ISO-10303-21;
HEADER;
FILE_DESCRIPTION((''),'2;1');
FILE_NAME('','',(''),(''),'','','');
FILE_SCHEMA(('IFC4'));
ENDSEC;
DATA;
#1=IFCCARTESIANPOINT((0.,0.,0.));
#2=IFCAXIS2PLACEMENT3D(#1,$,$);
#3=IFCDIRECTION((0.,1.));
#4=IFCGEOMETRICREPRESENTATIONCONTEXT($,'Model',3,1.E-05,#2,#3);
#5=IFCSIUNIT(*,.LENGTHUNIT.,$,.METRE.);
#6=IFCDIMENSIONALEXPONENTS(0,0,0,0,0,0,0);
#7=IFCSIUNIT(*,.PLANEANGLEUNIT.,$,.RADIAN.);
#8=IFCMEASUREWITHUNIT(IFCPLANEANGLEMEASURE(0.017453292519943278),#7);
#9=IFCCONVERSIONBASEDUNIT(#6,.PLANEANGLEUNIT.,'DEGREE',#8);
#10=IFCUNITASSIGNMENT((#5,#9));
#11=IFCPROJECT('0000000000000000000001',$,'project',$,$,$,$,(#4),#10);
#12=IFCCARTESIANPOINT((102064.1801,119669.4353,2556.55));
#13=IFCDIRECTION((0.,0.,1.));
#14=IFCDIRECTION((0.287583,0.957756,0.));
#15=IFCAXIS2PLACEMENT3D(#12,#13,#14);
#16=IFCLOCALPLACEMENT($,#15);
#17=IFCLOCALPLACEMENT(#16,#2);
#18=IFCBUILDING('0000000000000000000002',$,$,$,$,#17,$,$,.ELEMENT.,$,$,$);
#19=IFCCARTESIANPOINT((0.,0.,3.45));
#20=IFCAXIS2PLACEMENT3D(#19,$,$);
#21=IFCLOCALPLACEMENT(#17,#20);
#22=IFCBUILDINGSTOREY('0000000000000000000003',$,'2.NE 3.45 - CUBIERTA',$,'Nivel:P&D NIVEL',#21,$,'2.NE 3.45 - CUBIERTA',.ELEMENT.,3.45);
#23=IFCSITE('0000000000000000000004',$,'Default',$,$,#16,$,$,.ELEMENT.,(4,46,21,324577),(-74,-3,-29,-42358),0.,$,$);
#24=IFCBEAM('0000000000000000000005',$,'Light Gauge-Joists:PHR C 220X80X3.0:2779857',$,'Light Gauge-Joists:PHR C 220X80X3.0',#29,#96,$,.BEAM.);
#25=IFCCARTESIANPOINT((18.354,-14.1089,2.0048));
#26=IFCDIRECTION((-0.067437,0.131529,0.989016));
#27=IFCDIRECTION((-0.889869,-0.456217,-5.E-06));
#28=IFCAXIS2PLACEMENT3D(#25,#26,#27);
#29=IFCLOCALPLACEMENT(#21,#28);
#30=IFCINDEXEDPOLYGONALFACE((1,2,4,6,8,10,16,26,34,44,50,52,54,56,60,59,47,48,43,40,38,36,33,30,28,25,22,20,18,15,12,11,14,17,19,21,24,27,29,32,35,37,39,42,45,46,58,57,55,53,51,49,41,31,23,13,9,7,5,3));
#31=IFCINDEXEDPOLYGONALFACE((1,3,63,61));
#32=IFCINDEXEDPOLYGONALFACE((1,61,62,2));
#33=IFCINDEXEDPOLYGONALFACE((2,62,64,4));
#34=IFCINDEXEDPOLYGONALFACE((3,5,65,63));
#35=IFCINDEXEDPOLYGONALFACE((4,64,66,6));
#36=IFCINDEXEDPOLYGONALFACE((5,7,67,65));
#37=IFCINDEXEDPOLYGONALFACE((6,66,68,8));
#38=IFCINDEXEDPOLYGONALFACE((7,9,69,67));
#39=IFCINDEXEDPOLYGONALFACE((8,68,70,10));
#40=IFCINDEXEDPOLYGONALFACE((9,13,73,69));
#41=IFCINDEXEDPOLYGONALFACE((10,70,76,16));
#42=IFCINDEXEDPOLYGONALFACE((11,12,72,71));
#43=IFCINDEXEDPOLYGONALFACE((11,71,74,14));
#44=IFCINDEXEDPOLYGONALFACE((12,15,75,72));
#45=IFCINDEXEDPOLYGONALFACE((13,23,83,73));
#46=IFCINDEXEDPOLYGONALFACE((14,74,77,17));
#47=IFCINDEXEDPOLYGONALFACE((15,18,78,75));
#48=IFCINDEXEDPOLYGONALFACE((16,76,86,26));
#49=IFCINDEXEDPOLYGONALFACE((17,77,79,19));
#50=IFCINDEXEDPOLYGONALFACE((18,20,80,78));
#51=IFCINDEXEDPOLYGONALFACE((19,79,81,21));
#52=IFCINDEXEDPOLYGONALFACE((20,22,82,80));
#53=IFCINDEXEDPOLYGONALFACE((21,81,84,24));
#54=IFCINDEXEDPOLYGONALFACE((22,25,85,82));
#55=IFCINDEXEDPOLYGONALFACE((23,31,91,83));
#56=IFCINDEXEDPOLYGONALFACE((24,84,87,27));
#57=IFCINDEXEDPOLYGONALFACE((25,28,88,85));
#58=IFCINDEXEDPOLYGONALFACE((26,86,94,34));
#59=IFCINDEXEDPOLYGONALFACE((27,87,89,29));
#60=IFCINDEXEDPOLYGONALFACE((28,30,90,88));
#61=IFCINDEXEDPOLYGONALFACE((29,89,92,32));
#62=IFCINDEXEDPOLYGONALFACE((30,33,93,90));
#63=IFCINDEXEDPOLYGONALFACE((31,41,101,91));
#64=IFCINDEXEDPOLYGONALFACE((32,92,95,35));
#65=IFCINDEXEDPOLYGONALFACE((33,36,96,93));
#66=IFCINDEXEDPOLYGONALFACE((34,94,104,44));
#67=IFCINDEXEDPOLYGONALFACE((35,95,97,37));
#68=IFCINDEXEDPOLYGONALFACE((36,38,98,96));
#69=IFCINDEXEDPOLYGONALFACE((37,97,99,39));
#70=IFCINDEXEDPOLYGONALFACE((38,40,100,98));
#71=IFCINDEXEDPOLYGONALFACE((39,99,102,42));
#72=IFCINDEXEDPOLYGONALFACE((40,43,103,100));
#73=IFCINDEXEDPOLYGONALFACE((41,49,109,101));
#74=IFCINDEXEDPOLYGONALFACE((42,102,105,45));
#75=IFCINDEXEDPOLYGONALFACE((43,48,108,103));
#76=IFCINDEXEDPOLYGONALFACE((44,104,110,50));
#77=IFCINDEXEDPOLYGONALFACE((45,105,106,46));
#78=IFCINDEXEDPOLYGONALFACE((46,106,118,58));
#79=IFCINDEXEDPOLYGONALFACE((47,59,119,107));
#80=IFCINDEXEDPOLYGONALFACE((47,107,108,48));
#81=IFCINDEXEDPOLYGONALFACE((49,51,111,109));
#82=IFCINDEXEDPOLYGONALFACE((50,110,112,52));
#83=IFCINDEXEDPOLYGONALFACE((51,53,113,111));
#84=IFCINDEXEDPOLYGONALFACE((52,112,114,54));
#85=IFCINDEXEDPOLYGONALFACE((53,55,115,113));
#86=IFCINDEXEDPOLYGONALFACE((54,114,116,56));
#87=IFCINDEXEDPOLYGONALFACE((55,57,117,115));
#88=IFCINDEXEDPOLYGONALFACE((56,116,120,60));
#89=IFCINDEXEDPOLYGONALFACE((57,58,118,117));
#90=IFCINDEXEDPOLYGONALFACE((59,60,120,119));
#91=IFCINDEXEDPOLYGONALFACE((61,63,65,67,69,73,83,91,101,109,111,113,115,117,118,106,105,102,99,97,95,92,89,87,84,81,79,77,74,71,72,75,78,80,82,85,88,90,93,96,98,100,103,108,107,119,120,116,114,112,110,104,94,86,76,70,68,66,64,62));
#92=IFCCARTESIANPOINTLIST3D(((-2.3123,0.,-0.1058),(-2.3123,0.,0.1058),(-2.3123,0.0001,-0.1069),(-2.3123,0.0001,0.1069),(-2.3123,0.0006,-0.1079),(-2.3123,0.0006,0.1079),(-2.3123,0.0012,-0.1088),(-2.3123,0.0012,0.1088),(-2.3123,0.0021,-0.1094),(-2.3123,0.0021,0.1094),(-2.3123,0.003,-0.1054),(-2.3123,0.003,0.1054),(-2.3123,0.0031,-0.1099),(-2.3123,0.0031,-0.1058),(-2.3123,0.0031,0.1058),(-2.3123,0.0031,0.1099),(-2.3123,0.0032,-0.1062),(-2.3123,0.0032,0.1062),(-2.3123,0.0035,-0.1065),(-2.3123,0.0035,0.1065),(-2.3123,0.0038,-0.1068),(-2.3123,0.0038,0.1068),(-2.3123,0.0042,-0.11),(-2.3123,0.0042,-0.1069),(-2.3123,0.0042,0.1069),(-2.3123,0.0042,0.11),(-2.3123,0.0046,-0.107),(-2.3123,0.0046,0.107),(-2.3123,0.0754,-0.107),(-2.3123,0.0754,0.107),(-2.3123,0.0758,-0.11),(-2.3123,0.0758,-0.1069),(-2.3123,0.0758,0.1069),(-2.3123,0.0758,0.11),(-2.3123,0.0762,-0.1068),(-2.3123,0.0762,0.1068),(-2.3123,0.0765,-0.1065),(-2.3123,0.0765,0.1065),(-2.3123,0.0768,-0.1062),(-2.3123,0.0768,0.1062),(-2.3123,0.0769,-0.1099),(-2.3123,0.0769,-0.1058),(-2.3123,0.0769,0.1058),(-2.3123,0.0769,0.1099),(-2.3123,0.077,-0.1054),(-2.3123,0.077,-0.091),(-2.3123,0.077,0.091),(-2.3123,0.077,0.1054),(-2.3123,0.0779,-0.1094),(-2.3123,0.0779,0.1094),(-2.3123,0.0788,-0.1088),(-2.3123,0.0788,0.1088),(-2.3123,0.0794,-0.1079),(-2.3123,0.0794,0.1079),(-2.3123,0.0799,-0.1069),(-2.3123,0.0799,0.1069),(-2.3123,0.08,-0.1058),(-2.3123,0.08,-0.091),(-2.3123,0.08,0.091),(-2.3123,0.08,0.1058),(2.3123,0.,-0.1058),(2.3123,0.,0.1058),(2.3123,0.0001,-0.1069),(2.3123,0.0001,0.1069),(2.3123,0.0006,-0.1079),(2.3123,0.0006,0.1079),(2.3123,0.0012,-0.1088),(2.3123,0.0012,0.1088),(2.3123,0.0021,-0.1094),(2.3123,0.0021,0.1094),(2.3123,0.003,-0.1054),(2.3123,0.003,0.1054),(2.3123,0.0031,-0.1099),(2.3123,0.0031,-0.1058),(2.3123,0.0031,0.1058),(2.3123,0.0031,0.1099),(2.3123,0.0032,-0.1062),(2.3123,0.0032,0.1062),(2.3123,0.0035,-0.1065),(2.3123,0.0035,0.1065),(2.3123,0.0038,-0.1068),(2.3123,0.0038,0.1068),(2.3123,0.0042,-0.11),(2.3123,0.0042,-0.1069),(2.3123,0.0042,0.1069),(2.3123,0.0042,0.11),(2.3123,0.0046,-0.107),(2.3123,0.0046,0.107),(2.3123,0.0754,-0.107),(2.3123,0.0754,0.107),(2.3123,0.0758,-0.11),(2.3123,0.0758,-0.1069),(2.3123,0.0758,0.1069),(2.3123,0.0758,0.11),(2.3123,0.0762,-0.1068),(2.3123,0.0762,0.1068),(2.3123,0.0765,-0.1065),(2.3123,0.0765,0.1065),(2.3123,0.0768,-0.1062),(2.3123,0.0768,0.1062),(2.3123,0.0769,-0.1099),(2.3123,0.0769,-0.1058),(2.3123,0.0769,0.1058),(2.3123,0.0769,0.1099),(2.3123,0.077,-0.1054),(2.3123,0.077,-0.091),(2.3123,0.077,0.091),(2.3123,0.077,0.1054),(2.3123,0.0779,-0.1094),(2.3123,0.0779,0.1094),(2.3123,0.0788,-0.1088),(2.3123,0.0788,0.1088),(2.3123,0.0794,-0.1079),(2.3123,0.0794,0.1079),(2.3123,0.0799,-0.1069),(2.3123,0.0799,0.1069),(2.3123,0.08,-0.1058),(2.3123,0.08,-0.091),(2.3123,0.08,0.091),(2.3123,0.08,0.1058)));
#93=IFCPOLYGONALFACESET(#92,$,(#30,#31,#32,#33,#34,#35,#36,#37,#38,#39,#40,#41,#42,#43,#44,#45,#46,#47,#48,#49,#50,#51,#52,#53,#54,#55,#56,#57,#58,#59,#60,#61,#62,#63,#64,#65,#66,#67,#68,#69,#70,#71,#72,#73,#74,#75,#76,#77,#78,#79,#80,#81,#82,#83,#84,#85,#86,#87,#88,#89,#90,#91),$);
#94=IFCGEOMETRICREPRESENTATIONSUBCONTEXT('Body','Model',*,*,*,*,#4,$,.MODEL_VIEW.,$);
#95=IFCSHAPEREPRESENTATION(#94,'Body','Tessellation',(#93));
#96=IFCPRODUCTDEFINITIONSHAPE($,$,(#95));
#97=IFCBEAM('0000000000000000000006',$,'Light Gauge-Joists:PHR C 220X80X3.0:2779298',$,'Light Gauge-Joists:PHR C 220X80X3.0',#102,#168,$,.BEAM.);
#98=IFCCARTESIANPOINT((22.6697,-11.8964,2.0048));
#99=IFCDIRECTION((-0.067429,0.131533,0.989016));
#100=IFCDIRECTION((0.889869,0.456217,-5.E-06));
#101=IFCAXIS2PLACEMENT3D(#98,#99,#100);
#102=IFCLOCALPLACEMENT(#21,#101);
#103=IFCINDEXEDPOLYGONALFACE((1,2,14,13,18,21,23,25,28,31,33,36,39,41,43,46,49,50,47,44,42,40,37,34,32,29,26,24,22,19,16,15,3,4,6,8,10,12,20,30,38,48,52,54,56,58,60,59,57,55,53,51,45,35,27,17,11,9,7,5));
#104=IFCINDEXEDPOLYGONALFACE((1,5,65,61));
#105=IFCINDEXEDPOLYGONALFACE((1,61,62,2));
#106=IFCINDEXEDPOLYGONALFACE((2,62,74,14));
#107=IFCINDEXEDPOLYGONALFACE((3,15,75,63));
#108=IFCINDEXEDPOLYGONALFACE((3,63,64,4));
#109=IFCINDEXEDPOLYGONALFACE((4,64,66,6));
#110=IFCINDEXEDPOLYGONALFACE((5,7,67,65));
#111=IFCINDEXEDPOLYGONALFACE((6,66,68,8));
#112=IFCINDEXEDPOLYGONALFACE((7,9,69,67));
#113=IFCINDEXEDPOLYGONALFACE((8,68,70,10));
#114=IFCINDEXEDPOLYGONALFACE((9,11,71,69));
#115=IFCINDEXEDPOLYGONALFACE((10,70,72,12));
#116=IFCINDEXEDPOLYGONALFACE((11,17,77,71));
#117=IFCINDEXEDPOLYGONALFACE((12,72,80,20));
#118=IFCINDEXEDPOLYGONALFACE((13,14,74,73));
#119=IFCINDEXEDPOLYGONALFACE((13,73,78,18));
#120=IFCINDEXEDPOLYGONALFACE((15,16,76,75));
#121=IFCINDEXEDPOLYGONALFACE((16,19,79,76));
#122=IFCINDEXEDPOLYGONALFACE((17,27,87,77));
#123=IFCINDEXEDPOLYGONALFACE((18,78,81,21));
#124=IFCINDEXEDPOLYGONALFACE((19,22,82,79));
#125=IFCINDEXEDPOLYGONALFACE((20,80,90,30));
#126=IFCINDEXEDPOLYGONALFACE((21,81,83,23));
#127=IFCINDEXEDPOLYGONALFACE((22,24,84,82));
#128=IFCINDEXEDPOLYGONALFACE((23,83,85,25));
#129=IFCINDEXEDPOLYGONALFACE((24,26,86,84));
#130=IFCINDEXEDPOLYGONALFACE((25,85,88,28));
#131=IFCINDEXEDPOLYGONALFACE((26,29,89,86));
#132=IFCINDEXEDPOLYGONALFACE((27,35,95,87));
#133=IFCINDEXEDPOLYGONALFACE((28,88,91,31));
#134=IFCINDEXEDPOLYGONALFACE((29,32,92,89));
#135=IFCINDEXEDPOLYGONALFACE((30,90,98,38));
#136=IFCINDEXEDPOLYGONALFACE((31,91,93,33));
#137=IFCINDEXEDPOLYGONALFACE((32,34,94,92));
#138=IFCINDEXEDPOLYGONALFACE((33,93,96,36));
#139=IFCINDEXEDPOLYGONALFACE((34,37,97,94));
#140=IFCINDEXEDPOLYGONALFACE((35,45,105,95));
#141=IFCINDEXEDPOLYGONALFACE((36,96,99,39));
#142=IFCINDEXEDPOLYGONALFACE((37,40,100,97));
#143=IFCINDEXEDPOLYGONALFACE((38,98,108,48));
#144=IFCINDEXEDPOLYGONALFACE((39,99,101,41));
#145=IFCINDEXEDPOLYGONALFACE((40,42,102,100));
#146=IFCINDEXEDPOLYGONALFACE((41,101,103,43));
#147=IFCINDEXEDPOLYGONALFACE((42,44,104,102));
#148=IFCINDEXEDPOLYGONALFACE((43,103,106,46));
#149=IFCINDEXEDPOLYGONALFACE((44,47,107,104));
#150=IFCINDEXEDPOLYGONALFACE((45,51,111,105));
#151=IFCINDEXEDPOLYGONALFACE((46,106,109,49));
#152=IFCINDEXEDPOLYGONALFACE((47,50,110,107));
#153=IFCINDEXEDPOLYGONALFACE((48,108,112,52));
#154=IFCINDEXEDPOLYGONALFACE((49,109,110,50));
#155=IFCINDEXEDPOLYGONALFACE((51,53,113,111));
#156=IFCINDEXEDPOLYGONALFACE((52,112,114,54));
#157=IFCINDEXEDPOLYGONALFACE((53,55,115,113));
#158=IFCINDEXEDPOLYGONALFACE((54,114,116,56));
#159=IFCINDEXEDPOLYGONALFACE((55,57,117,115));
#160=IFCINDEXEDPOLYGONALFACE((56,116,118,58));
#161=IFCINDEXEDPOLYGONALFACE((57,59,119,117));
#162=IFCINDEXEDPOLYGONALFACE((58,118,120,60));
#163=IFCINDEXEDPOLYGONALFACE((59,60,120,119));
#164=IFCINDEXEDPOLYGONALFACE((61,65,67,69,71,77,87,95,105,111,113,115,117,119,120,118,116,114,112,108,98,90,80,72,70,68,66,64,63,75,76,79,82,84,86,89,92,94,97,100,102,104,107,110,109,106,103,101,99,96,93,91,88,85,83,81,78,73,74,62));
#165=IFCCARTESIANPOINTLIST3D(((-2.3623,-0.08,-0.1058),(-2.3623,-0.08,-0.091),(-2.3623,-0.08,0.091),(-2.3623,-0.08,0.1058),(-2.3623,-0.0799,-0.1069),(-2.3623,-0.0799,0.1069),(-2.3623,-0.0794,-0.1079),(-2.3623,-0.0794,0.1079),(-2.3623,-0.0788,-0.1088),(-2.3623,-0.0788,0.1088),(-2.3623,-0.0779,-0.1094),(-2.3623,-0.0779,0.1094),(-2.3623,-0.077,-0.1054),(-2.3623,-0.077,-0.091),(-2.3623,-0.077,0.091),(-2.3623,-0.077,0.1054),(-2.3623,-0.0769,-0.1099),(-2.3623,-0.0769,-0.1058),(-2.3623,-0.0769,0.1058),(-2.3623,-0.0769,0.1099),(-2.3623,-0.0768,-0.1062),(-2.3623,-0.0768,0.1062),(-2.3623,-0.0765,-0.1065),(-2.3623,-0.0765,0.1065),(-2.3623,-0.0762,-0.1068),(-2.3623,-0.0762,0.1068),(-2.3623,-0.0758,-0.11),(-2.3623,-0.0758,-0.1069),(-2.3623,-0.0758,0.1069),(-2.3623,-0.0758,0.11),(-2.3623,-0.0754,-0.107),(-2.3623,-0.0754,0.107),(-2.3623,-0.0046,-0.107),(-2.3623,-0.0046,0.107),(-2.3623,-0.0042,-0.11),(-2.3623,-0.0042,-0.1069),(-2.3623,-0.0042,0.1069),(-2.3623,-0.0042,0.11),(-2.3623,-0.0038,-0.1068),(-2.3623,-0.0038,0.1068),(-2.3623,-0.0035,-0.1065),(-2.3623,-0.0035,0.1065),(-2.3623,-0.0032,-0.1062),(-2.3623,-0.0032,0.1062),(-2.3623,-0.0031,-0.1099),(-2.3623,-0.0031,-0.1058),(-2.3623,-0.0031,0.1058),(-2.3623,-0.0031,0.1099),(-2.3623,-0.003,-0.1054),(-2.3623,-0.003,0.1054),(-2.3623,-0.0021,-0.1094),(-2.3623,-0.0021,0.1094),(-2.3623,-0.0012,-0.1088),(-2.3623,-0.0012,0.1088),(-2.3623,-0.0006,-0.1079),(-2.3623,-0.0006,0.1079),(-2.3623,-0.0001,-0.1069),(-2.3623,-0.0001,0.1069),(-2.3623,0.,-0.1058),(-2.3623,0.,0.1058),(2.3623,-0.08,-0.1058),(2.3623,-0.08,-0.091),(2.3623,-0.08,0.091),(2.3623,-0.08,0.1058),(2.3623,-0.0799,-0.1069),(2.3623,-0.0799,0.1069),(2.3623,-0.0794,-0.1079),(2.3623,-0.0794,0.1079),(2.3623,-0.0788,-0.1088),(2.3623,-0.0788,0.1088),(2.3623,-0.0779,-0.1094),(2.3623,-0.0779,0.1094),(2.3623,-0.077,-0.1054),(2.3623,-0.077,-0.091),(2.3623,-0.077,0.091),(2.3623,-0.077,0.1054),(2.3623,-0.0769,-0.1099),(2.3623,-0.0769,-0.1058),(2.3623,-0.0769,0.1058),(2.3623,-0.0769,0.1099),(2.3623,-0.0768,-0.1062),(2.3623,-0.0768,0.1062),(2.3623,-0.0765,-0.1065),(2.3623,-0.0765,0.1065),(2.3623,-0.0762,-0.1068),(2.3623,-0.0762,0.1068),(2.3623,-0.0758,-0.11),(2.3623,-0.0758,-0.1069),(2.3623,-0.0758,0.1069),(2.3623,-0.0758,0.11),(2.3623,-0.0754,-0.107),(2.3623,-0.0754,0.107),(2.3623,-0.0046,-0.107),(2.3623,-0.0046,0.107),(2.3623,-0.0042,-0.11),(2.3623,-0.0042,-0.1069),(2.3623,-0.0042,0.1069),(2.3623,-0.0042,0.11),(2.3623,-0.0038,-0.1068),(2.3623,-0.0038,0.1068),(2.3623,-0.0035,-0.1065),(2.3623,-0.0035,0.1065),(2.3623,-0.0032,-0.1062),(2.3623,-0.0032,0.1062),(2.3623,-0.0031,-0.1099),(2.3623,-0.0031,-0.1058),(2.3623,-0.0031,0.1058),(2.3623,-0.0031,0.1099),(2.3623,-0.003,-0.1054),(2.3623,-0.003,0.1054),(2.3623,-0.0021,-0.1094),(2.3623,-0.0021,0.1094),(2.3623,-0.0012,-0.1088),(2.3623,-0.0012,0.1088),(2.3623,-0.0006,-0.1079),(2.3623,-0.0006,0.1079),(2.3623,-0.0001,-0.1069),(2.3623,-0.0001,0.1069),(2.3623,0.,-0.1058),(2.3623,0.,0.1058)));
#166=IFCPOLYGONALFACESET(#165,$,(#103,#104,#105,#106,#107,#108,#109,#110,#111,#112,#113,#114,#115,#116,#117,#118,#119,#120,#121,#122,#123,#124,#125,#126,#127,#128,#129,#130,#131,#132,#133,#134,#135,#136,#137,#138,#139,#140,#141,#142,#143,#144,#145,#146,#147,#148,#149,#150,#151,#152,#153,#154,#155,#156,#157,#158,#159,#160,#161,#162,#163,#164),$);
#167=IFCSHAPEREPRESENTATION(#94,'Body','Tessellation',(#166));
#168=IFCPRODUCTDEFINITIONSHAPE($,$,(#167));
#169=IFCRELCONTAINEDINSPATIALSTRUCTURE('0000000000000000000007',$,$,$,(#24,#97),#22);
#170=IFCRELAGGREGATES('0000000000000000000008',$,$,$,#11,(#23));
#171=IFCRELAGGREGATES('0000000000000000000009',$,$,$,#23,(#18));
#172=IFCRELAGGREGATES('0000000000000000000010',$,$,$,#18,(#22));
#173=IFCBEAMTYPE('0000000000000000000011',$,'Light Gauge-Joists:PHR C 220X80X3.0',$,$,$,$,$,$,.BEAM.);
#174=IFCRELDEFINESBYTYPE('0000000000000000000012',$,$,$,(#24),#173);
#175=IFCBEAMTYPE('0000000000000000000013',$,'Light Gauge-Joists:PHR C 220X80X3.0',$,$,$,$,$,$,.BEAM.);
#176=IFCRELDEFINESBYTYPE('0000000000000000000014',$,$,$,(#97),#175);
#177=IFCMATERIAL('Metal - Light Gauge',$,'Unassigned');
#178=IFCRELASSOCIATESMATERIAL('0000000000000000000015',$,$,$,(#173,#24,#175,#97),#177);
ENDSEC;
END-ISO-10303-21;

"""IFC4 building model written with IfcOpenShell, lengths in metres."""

from ifc_helpers import new_model, entity, si_unit, converted_unit, direction, frame, origin, place, context, subcontext, project, spatial, line, arc, indexed_curve, outline, extrude, source, transform, mapped, material, type_object, type_shapes, element, save


model = new_model("IFC4")

# Units and contexts
model_context = context("Model", 3, precision=1e-05, world=origin(), true_north=direction((0.0, 1.0)))
body_context = subcontext(model_context, "Body", "Model", "MODEL_VIEW")
ifc_project = project(units=[si_unit("LENGTHUNIT", "METRE"), converted_unit("PLANEANGLEUNIT", "DEGREE", entity("IfcPlaneAngleMeasure", 0.017453292519943278), si_unit("PLANEANGLEUNIT", "RADIAN"), dimensions=[0, 0, 0, 0, 0, 0, 0])], contexts=[model_context])

# Site, building, storey
site_placement = place(None, frame((102064.1801, 119669.4353, 2556.55), z_axis=(0.0, 0.0, 1.0), x_axis=(0.287583, 0.957756, 0.0)))
site = spatial("IfcSite", under=ifc_project, at=site_placement, Name="Default", CompositionType="ELEMENT", RefLatitude=(4, 46, 21, 324577), RefLongitude=(-74, -3, -29, -42358), RefElevation=0.0)
building_placement = place(site_placement, origin())
building = spatial("IfcBuilding", under=site, at=building_placement, CompositionType="ELEMENT")
storey_placement = place(building_placement, frame((0.0, 0.0, 3.45)))
storey = spatial("IfcBuildingStorey", under=building, at=storey_placement, Name="2.NE 3.45 - CUBIERTA", ObjectType="Nivel:P&D NIVEL", LongName="2.NE 3.45 - CUBIERTA", CompositionType="ELEMENT", Elevation=3.45)

# Beams
ifc_material_1 = material(Name="Metal - Light Gauge", Category="Unassigned")
beam_type_1 = type_object("IfcBeamType", Name="Light Gauge-Joists:PHR C 220X80X3.0", PredefinedType="BEAM", material=ifc_material_1)
shared_shape_1 = source(origin(), body_context, "Body", "SweptSolid", [
    extrude(outline(indexed_curve([(-0.0477, -0.1058), (-0.0465, -0.1088), (-0.0435, -0.11), (0.0281, -0.11), (0.0311, -0.1088), (0.0323, -0.1058), (0.0323, -0.091), (0.0293, -0.091), (0.0293, -0.1054), (0.0288, -0.1065), (0.0277, -0.107), (-0.0431, -0.107), (-0.0442, -0.1065), (-0.0447, -0.1054), (-0.0447, 0.1054), (-0.0442, 0.1065), (-0.0431, 0.107), (0.0277, 0.107), (0.0288, 0.1065), (0.0293, 0.1054), (0.0293, 0.091), (0.0323, 0.091), (0.0323, 0.1058), (0.0311, 0.1088), (0.0281, 0.11), (-0.0435, 0.11), (-0.0465, 0.1088), (-0.0477, 0.1058)], segments=[arc(1, 2, 3), line(3, 4), arc(4, 5, 6), line(6, 7, 8, 9), arc(9, 10, 11), line(11, 12), arc(12, 13, 14), line(14, 15), arc(15, 16, 17), line(17, 18), arc(18, 19, 20), line(20, 21, 22, 23), arc(23, 24, 25), line(25, 26), arc(26, 27, 28), line(28, 1)], self_intersect=False)), frame((-2.3123, 0.0477, 0.0), z_axis=(1.0, 0.0, 0.0), x_axis=(0.0, 1.0, 0.0)), (0.0, 0.0, 1.0), 4.6246),
])
type_shapes(beam_type_1, [shared_shape_1])
for number, where, z_axis, x_axis, name in (
    (1, (18.354, -14.1089, 2.0048), (-0.067437, 0.131529, 0.989016), (-0.889869, -0.456217, -0.000005), "Light Gauge-Joists:PHR C 220X80X3.0:2779857"),
):
    element("IfcBeam", number, at=place(storey_placement, frame(where, z_axis=z_axis, x_axis=x_axis)), inside=storey, type_object=beam_type_1, material=ifc_material_1, Name=name, ObjectType="Light Gauge-Joists:PHR C 220X80X3.0", PredefinedType="BEAM", context=body_context, shape_type="MappedRepresentation", body=[
        mapped(shared_shape_1, transform((0.0, 0.0, 0.0), scale=1.0)),
    ])
beam_type_2 = type_object("IfcBeamType", Name="Light Gauge-Joists:PHR C 220X80X3.0", PredefinedType="BEAM", material=ifc_material_1)
shared_shape_2 = source(origin(), body_context, "Body", "SweptSolid", [
    extrude(outline(indexed_curve([(-0.1058, -0.0477), (0.1058, -0.0477), (0.1088, -0.0465), (0.11, -0.0435), (0.11, 0.0281), (0.1088, 0.0311), (0.1058, 0.0323), (0.091, 0.0323), (0.091, 0.0293), (0.1054, 0.0293), (0.1065, 0.0288), (0.107, 0.0277), (0.107, -0.0431), (0.1065, -0.0442), (0.1054, -0.0447), (-0.1054, -0.0447), (-0.1065, -0.0442), (-0.107, -0.0431), (-0.107, 0.0277), (-0.1065, 0.0288), (-0.1054, 0.0293), (-0.091, 0.0293), (-0.091, 0.0323), (-0.1058, 0.0323), (-0.1088, 0.0311), (-0.11, 0.0281), (-0.11, -0.0435), (-0.1088, -0.0465)], segments=[line(1, 2), arc(2, 3, 4), line(4, 5), arc(5, 6, 7), line(7, 8, 9, 10), arc(10, 11, 12), line(12, 13), arc(13, 14, 15), line(15, 16), arc(16, 17, 18), line(18, 19), arc(19, 20, 21), line(21, 22, 23, 24), arc(24, 25, 26), line(26, 27), arc(27, 28, 1)], self_intersect=False)), frame((-2.3623, -0.0477, 0.0), z_axis=(1.0, 0.0, 0.0), x_axis=(0.0, 0.0, 1.0)), (0.0, 0.0, 1.0), 4.7246),
])
type_shapes(beam_type_2, [shared_shape_2])
for number, where, z_axis, x_axis, name in (
    (2, (22.6697, -11.8964, 2.0048), (-0.067429, 0.131533, 0.989016), (0.889869, 0.456217, -0.000005), "Light Gauge-Joists:PHR C 220X80X3.0:2779298"),
):
    element("IfcBeam", number, at=place(storey_placement, frame(where, z_axis=z_axis, x_axis=x_axis)), inside=storey, type_object=beam_type_2, material=ifc_material_1, Name=name, ObjectType="Light Gauge-Joists:PHR C 220X80X3.0", PredefinedType="BEAM", context=body_context, shape_type="MappedRepresentation", body=[
        mapped(shared_shape_2, transform((0.0, 0.0, 0.0), scale=1.0)),
    ])

save(model, "model.ifc")
